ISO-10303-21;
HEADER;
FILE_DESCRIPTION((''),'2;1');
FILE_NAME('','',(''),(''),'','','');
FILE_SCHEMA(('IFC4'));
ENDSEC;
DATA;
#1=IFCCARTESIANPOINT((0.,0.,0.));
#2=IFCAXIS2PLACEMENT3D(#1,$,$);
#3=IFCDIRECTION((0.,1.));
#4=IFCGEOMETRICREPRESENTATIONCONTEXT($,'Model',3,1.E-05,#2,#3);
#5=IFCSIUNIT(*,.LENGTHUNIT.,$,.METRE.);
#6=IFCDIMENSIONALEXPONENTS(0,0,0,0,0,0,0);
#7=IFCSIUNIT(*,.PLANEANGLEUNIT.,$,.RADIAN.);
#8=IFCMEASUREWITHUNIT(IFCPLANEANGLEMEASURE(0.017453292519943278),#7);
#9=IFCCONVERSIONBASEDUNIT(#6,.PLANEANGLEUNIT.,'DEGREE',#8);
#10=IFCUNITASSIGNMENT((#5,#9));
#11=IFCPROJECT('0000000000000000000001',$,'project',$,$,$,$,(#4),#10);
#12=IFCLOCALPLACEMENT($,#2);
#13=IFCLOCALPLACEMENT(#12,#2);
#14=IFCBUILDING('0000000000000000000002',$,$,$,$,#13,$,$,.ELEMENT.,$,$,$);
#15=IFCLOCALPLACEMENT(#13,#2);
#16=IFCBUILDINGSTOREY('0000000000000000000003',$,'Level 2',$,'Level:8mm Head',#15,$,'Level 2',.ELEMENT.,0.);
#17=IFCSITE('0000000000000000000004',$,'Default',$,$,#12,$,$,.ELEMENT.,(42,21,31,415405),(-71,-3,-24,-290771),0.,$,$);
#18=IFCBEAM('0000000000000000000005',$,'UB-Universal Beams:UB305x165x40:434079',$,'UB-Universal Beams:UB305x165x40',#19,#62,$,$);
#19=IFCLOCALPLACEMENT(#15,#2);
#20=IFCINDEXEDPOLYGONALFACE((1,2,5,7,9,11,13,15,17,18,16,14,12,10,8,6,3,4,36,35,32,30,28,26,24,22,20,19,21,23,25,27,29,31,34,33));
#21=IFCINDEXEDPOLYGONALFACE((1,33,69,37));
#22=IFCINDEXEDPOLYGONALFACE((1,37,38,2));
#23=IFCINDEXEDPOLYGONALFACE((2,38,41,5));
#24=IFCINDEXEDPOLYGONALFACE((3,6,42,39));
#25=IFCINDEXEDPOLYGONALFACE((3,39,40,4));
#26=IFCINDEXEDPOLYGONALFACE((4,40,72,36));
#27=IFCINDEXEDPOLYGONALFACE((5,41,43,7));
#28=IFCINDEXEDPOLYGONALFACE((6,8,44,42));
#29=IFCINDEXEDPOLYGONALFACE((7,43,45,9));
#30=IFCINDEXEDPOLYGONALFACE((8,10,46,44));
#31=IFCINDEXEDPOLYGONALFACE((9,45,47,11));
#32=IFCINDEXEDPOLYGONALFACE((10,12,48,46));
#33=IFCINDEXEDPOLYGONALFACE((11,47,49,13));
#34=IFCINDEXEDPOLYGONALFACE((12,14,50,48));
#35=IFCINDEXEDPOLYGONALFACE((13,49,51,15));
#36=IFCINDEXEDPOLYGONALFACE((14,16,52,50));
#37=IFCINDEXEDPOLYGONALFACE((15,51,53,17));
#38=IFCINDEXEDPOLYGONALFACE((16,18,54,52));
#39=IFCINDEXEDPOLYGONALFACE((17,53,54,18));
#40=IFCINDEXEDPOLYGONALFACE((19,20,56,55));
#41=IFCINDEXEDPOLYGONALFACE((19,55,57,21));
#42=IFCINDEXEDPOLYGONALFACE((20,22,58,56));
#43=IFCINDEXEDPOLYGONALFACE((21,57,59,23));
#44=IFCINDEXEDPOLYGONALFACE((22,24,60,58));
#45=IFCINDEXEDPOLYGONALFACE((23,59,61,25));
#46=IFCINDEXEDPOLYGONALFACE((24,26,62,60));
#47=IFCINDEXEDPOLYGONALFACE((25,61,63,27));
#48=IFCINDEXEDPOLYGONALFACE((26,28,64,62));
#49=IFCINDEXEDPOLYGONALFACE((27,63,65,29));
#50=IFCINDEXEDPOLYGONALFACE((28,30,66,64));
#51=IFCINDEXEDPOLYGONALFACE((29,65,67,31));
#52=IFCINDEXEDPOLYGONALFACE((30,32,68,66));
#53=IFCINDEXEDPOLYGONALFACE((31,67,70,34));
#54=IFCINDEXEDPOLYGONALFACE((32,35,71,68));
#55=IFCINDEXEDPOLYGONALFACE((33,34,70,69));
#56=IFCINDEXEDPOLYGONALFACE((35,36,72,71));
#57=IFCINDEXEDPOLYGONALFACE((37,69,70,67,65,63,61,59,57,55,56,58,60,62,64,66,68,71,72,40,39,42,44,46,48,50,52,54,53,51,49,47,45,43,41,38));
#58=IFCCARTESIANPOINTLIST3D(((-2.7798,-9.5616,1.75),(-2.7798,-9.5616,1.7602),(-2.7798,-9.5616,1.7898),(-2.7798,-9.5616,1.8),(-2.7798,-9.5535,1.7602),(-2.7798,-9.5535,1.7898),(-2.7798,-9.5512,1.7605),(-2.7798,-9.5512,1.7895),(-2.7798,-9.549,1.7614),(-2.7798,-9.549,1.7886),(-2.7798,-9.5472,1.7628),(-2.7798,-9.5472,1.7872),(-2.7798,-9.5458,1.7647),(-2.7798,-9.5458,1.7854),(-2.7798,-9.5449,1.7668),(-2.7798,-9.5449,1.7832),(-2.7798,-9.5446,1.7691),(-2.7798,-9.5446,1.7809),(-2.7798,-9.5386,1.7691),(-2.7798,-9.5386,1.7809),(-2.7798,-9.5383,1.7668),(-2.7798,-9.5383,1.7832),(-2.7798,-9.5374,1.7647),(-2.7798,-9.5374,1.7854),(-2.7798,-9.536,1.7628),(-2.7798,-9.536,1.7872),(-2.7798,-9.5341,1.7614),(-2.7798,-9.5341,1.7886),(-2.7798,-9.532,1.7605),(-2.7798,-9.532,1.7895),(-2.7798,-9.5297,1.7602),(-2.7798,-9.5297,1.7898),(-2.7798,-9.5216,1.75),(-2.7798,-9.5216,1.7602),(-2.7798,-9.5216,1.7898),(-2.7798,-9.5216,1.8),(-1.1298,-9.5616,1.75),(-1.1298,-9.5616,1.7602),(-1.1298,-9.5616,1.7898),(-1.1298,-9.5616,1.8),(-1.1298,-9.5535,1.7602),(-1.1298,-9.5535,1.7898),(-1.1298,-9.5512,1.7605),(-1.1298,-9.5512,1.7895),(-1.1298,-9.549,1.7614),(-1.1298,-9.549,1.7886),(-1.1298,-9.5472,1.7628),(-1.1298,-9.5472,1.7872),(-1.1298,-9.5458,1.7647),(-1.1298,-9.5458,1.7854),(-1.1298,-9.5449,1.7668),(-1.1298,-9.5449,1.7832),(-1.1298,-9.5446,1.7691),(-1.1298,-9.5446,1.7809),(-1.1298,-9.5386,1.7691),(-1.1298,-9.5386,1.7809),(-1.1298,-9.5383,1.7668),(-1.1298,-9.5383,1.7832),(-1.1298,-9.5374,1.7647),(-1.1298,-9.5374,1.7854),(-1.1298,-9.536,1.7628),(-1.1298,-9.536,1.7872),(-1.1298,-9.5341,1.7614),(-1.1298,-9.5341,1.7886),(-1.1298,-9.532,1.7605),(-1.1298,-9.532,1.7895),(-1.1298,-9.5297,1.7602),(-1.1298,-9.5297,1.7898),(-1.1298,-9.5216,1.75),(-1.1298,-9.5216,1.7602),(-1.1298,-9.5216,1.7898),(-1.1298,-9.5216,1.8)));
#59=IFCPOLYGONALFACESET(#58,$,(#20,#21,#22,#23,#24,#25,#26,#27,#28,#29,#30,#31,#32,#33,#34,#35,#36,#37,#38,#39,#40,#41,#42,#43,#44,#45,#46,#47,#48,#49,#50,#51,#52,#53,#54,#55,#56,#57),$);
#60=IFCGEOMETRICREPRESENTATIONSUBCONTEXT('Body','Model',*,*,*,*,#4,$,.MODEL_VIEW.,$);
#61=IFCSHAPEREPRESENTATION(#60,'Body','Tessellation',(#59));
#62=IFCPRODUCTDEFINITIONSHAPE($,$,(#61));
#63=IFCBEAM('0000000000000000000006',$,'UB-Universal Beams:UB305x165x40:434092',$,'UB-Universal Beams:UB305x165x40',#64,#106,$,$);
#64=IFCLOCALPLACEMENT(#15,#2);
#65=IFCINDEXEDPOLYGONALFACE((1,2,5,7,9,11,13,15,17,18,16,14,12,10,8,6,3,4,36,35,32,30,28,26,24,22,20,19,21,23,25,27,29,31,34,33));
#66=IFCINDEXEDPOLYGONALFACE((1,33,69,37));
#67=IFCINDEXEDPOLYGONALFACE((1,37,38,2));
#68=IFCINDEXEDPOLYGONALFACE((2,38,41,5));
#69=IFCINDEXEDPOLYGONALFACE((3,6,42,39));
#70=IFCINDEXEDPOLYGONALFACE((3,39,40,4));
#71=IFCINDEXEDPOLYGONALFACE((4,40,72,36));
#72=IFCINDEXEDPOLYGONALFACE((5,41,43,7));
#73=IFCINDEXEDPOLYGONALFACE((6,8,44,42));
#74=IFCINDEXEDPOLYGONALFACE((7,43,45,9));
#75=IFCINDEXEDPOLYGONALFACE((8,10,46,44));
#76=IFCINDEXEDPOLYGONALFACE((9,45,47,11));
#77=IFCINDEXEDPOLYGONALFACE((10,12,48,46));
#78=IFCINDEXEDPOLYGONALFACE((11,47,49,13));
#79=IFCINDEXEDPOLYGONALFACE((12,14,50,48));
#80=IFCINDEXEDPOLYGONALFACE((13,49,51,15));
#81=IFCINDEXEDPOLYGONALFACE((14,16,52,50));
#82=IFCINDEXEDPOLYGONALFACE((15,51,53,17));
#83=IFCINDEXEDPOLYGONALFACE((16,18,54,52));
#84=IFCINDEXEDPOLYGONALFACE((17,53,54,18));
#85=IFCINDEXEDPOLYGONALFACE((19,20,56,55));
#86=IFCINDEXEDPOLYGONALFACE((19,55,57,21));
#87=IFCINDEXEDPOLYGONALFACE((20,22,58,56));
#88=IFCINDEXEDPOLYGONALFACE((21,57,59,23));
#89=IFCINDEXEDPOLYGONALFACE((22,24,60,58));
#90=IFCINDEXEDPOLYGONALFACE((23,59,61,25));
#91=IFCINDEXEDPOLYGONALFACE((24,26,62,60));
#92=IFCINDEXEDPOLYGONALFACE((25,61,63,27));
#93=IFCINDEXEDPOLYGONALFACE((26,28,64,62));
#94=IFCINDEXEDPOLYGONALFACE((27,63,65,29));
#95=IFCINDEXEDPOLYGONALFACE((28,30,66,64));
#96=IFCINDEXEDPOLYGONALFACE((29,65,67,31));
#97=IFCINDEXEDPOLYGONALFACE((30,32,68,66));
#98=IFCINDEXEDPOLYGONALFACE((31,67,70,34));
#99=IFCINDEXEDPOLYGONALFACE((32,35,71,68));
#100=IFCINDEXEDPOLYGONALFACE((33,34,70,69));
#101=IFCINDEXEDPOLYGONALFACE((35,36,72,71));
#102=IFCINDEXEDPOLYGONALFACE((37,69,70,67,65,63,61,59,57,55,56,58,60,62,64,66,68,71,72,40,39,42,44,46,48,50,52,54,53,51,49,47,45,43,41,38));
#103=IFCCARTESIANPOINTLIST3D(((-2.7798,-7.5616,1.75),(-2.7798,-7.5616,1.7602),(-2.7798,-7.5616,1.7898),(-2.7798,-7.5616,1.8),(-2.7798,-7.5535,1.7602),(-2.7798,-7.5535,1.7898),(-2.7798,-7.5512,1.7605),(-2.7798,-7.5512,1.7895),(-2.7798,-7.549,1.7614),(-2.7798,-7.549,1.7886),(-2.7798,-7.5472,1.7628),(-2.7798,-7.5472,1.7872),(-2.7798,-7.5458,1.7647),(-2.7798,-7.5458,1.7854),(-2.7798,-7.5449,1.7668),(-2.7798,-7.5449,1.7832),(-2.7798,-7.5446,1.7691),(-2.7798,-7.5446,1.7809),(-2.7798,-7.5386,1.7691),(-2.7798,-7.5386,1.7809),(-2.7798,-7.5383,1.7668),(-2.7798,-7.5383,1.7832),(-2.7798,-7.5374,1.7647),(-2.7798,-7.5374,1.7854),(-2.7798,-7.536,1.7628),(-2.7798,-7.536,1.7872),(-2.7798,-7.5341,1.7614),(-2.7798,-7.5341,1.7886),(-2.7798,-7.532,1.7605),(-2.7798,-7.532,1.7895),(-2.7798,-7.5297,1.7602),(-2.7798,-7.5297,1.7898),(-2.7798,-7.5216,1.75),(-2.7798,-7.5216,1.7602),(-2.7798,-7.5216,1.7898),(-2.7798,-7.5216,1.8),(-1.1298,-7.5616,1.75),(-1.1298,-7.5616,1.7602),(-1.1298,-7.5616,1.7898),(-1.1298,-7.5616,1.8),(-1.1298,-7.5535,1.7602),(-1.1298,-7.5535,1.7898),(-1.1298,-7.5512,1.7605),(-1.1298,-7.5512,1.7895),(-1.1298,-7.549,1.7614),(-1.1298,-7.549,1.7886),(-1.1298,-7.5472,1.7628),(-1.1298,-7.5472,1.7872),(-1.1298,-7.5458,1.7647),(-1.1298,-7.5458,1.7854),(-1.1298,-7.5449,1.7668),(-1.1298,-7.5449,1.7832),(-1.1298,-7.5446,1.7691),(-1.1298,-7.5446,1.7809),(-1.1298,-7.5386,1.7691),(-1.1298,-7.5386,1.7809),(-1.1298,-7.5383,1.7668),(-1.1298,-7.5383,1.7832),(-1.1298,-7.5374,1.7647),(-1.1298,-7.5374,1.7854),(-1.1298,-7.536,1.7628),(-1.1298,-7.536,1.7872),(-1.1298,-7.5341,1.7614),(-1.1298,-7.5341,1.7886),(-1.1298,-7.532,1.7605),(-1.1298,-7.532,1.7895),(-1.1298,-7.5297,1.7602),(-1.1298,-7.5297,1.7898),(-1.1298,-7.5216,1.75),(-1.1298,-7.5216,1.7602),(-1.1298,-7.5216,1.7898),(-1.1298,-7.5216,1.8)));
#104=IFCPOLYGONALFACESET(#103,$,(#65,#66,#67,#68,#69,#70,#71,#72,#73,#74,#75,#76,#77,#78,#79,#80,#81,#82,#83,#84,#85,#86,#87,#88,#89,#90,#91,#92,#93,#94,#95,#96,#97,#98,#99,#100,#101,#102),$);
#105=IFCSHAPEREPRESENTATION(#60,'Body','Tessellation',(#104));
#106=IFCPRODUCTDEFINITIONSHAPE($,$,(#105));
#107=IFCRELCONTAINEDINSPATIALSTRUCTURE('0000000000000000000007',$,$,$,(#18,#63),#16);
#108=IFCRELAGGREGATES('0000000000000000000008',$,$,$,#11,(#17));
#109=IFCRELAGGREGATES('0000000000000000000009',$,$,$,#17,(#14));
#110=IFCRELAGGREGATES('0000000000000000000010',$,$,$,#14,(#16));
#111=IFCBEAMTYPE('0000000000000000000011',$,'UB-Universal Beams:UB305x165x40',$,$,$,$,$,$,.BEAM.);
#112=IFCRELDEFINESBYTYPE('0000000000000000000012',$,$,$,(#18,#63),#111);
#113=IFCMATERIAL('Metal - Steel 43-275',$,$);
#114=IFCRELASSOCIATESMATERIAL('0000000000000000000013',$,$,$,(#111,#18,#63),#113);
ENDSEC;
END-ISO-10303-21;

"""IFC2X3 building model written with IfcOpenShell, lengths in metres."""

from ifc_helpers import new_model, entity, si_unit, converted_unit, direction, frame, frame_2d, origin, place, context, subcontext, project, spatial, i_section, extrude, material, type_object, element, save


model = new_model("IFC2X3")

# Units and contexts
model_context = context("Model", 3, precision=1e-05, world=origin(), true_north=direction((0.0, 1.0)))
body_context = subcontext(model_context, "Body", "Model", "MODEL_VIEW")
ifc_project = project(units=[si_unit("LENGTHUNIT", "METRE"), converted_unit("PLANEANGLEUNIT", "DEGREE", entity("IfcPlaneAngleMeasure", 0.017453292519943278), si_unit("PLANEANGLEUNIT", "RADIAN"), dimensions=[0, 0, 0, 0, 0, 0, 0])], contexts=[model_context])

# Site, building, storey
site_placement = place(None, origin())
site = spatial("IfcSite", under=ifc_project, at=site_placement, Name="Default", CompositionType="ELEMENT", RefLatitude=(42, 21, 31, 415405), RefLongitude=(-71, -3, -24, -290771), RefElevation=0.0)
building_placement = place(site_placement, origin())
building = spatial("IfcBuilding", under=site, at=building_placement, CompositionType="ELEMENT")
storey_placement = place(building_placement, origin())
storey = spatial("IfcBuildingStorey", under=building, at=storey_placement, Name="Level 2", ObjectType="Level:8mm Head", LongName="Level 2", CompositionType="ELEMENT", Elevation=0.0)

# Shared definitions
ifc_material = material(Name="Metal - Steel 43-275")

# Beams
beam_type = type_object("IfcBeamType", Name="UB-Universal Beams:UB305x165x40", PredefinedType="BEAM", material=ifc_material)
beam_1_placement = place(storey_placement, frame((-2.7798, -9.5416, 1.8)))
element("IfcBeam", 1, at=beam_1_placement, inside=storey, type_object=beam_type, material=ifc_material, Name="UB-Universal Beams:UB305x165x40:434079", ObjectType="UB-Universal Beams:UB305x165x40", context=body_context, shape_type="SweptSolid", body=[
    extrude(i_section(OverallWidth=0.04, OverallDepth=0.05, WebThickness=0.006, FlangeThickness=0.0102, FilletRadius=0.0089, at=frame_2d((0.0, 0.0), x_axis=(0.0, 1.0))), frame((0.0, 0.0, -0.025), z_axis=(1.0, 0.0, 0.0), x_axis=(0.0, 0.0, -1.0)), (0.0, 0.0, 1.0), 1.65),
])
beam_2_placement = place(storey_placement, frame((-2.7798, -7.5416, 1.8)))
element("IfcBeam", 2, at=beam_2_placement, inside=storey, type_object=beam_type, material=ifc_material, Name="UB-Universal Beams:UB305x165x40:434092", ObjectType="UB-Universal Beams:UB305x165x40", context=body_context, shape_type="SweptSolid", body=[
    extrude(i_section(OverallWidth=0.04, OverallDepth=0.05, WebThickness=0.006, FlangeThickness=0.0102, FilletRadius=0.0089, at=frame_2d((0.0, 0.0), x_axis=(0.0, 1.0))), frame((0.0, 0.0, -0.025), z_axis=(1.0, 0.0, 0.0), x_axis=(0.0, 0.0, -1.0)), (0.0, 0.0, 1.0), 1.65),
])

save(model, "model.ifc")
